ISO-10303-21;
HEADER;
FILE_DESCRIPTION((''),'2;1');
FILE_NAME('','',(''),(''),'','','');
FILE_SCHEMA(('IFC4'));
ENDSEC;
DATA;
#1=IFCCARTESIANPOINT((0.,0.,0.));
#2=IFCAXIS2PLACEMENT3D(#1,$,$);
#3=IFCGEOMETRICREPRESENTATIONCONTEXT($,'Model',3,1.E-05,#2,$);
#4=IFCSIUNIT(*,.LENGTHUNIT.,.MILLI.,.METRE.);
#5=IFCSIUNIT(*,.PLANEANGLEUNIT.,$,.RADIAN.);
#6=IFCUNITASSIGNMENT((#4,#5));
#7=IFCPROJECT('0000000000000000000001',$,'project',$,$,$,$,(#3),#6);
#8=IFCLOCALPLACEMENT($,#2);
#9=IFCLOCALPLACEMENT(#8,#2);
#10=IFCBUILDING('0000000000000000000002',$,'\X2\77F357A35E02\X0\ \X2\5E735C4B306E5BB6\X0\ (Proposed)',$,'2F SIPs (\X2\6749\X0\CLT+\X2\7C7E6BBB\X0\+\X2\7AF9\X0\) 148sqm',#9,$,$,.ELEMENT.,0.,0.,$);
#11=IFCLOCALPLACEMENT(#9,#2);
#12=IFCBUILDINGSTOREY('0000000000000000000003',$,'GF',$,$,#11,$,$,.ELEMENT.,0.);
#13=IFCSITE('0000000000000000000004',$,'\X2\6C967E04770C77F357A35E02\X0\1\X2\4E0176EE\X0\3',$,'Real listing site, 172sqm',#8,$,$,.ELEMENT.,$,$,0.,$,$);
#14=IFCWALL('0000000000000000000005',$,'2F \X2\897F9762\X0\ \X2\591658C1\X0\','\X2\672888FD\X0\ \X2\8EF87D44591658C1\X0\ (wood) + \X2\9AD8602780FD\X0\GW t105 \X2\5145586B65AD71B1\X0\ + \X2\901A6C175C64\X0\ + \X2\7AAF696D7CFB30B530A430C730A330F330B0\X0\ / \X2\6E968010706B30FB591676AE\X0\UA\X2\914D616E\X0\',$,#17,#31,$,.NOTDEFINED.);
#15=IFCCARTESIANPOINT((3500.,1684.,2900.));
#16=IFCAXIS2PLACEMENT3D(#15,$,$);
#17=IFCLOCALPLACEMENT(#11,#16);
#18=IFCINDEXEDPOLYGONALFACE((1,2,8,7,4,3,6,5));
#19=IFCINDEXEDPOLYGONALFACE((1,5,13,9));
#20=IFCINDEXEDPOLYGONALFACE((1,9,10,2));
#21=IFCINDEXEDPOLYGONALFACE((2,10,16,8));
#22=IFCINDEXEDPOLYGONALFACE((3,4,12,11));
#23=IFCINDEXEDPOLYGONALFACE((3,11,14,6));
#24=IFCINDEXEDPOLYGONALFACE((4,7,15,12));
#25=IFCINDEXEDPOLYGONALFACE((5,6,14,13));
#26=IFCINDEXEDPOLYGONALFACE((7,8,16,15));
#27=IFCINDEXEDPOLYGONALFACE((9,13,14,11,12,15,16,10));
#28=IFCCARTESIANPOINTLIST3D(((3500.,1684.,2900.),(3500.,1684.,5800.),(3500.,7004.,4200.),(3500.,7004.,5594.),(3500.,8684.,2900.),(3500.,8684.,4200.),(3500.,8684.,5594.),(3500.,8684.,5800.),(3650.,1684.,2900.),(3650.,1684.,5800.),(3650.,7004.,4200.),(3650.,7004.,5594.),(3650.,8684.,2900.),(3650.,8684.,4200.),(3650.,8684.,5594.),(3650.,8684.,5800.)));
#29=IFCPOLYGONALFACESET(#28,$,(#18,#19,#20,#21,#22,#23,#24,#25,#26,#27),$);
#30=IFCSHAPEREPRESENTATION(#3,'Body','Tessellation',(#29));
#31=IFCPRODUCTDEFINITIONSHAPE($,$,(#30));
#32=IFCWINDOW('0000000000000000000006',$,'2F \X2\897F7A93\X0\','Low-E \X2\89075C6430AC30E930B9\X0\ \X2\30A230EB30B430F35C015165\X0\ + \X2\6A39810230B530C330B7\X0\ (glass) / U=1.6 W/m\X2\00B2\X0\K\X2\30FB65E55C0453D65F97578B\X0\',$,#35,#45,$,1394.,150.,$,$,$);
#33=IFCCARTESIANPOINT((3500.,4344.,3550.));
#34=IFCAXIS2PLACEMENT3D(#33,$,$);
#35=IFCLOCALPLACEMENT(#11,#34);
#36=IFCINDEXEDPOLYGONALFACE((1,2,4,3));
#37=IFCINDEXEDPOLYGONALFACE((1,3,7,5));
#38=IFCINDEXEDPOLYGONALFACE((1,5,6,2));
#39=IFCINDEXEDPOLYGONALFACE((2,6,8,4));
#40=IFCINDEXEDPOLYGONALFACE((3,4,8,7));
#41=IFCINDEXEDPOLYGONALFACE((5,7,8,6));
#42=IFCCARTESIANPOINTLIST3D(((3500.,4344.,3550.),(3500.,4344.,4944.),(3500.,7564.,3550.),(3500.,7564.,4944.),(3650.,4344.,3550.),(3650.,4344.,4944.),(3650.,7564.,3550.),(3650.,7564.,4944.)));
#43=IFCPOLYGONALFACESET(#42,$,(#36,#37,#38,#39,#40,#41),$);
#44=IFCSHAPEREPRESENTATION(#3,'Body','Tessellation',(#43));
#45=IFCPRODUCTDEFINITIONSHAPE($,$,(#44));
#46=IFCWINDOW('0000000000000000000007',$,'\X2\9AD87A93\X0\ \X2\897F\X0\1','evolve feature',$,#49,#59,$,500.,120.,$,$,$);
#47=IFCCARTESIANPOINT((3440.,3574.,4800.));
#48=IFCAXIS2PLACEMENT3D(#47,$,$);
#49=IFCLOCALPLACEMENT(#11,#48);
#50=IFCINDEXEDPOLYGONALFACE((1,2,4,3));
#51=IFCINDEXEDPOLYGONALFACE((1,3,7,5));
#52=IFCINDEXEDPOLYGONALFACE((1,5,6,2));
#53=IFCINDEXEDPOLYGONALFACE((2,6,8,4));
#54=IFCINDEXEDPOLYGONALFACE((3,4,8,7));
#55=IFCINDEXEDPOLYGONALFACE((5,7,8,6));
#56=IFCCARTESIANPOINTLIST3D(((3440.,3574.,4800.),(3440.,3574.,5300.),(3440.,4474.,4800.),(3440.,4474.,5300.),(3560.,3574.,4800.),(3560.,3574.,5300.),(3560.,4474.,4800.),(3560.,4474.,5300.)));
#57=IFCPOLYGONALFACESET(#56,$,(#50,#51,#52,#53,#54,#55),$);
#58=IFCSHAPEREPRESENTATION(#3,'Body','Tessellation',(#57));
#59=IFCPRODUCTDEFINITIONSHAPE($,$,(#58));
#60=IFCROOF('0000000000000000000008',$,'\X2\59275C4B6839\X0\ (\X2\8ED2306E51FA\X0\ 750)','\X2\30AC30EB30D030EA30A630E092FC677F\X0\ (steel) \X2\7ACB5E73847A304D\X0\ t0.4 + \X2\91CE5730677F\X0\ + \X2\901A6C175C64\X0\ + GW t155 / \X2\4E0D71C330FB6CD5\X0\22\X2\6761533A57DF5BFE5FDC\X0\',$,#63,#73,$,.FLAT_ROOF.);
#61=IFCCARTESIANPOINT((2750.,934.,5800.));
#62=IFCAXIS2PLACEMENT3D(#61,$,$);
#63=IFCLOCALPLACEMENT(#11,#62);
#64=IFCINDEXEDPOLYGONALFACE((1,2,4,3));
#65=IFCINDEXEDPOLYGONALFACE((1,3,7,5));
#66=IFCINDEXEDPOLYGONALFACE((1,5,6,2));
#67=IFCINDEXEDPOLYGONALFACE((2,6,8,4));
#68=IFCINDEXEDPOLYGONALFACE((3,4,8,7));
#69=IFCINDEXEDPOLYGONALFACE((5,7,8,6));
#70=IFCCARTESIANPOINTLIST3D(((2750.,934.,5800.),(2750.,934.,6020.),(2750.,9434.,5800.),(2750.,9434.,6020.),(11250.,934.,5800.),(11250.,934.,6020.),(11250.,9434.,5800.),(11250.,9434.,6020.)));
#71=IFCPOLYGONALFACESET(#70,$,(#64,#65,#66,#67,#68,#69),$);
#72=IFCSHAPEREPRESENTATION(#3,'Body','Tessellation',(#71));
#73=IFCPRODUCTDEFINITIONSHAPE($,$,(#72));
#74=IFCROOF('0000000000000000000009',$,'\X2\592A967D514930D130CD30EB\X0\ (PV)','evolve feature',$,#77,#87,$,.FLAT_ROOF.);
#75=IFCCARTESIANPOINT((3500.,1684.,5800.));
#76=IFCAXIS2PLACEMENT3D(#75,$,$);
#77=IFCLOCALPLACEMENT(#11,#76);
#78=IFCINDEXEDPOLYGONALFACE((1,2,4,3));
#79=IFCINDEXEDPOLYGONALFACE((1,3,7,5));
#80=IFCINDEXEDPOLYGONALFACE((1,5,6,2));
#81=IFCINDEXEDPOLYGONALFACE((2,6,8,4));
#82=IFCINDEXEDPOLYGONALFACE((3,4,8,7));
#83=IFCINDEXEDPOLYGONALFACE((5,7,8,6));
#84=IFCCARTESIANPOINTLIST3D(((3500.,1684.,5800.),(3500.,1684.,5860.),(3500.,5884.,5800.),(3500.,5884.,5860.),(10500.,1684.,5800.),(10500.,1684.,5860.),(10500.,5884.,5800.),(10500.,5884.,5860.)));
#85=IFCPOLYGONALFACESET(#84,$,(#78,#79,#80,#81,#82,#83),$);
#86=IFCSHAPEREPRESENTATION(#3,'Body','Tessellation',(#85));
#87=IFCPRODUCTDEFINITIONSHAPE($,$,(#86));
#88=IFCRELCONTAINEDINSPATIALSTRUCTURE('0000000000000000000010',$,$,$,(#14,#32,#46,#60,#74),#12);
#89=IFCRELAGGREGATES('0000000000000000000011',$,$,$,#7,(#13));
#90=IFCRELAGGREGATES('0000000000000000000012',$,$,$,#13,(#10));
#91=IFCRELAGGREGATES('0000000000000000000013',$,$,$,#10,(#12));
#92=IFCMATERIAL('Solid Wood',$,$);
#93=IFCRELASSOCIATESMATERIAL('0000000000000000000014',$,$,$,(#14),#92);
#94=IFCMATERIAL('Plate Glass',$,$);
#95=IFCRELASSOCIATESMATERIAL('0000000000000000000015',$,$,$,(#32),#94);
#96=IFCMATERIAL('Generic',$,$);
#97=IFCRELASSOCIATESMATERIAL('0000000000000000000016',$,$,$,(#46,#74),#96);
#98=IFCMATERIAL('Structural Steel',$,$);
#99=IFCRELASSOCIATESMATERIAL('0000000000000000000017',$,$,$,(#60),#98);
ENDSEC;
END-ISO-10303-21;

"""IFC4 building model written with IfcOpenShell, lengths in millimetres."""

from ifc_helpers import new_model, si_unit, frame, frame_2d, origin, place, context, project, spatial, rectangle, extrude, material, element, fill, save


model = new_model("IFC4")

# Units and contexts
model_context = context("Model", 3, precision=1e-05, world=origin())
ifc_project = project(units=[si_unit("LENGTHUNIT", "METRE", prefix="MILLI"), si_unit("PLANEANGLEUNIT", "RADIAN")], contexts=[model_context])

# Site, building, storey
site_placement = place(None, origin())
site = spatial("IfcSite", under=ifc_project, at=site_placement, Name="沖縄県石垣市1丁目3", ObjectType="Real listing site, 172sqm", CompositionType="ELEMENT", RefElevation=0.0)
building_placement = place(site_placement, origin())
building = spatial("IfcBuilding", under=site, at=building_placement, Name="石垣市 平屋の家 (Proposed)", ObjectType="2F SIPs (杉CLT+籾殻+竹) 148sqm", CompositionType="ELEMENT", ElevationOfRefHeight=0.0, ElevationOfTerrain=0.0)
storey_placement = place(building_placement, origin())
storey = spatial("IfcBuildingStorey", under=building, at=storey_placement, Name="GF", CompositionType="ELEMENT", Elevation=0.0)

# Shared definitions
ifc_material_1 = material(Name="Solid Wood")
ifc_material_2 = material(Name="Generic")

# Shared definitions
ifc_material_3 = material(Name="Plate Glass")

# Wall, openings, windows
wall_1_placement = place(storey_placement, frame((3500.0, 1684.0, 2900.0)))
wall_1 = element("IfcWall", 1, at=wall_1_placement, inside=storey, material=ifc_material_1, Name="2F 西面 外壁", Description="木製 軸組外壁 (wood) + 高性能GW t105 充填断熱 + 通気層 + 窯業系サイディング / 準耐火・外皮UA配慮", PredefinedType="NOTDEFINED", context=model_context, shape_type="SweptSolid", body=[
    extrude(rectangle(XDim=150.0, YDim=7000.0, at=frame_2d((75.0, 3500.0))), frame((3500.0, 1684.0, 2900.0)), (0.0, 0.0, 1.0), 2900.0),
])
opening_1_placement = place(storey_placement, frame((3500.0, 4344.0, 3550.0)))
opening_1 = element("IfcOpeningElement", 2, at=opening_1_placement, cuts=wall_1, PredefinedType="NOTDEFINED", context=model_context, shape_type="SweptSolid", body=[
    extrude(rectangle(XDim=150.0, YDim=3220.0, at=frame_2d((75.0, 1610.0))), frame((3500.0, 4344.0, 3550.0)), (0.0, 0.0, 1.0), 1394.0),
])
opening_2_placement = place(storey_placement, frame((3440.0, 3574.0, 4800.0)))
opening_2 = element("IfcOpeningElement", 3, at=opening_2_placement, cuts=wall_1, PredefinedType="NOTDEFINED", context=model_context, shape_type="SweptSolid", body=[
    extrude(rectangle(XDim=120.0, YDim=900.0, at=frame_2d((60.0, 450.0))), frame((3440.0, 3574.0, 4800.0)), (0.0, 0.0, 1.0), 500.0),
])
window_1_placement = place(storey_placement, frame((3500.0, 4344.0, 3550.0)))
window_1 = element("IfcWindow", 4, at=window_1_placement, inside=storey, material=ifc_material_3, Name="2F 西窓", Description="Low-E 複層ガラス アルゴン封入 + 樹脂サッシ (glass) / U=1.6 W/m²K・日射取得型", OverallHeight=1394.0, OverallWidth=150.0, context=model_context, shape_type="SweptSolid", body=[
    extrude(rectangle(XDim=150.0, YDim=3220.0, at=frame_2d((75.0, 1610.0))), frame((3500.0, 4344.0, 3550.0)), (0.0, 0.0, 1.0), 1394.0),
])
fill(opening_1, window_1)
window_2_placement = place(storey_placement, frame((3440.0, 3574.0, 4800.0)))
window_2 = element("IfcWindow", 5, at=window_2_placement, inside=storey, material=ifc_material_2, Name="高窓 西1", Description="evolve feature", OverallHeight=500.0, OverallWidth=120.0, context=model_context, shape_type="SweptSolid", body=[
    extrude(rectangle(XDim=120.0, YDim=900.0, at=frame_2d((60.0, 450.0))), frame((3440.0, 3574.0, 4800.0)), (0.0, 0.0, 1.0), 500.0),
])
fill(opening_2, window_2)

# Roofs
ifc_material_4 = material(Name="Structural Steel")
roof_1_placement = place(storey_placement, frame((2750.0, 934.0, 5800.0)))
element("IfcRoof", 6, at=roof_1_placement, inside=storey, material=ifc_material_4, Name="大屋根 (軒の出 750)", Description="ガルバリウム鋼板 (steel) 立平葺き t0.4 + 野地板 + 通気層 + GW t155 / 不燃・法22条区域対応", PredefinedType="FLAT_ROOF", context=model_context, shape_type="SweptSolid", body=[
    extrude(rectangle(XDim=8500.0, YDim=8500.0, at=frame_2d((4250.0, 4250.0))), frame((2750.0, 934.0, 5800.0)), (0.0, 0.0, 1.0), 220.0),
])
roof_2_placement = place(storey_placement, frame((3500.0, 1684.0, 5800.0)))
element("IfcRoof", 7, at=roof_2_placement, inside=storey, material=ifc_material_2, Name="太陽光パネル (PV)", Description="evolve feature", PredefinedType="FLAT_ROOF", context=model_context, shape_type="SweptSolid", body=[
    extrude(rectangle(XDim=7000.0, YDim=4200.0, at=frame_2d((3500.0, 2100.0))), frame((3500.0, 1684.0, 5800.0)), (0.0, 0.0, 1.0), 60.0),
])

save(model, "model.ifc")
